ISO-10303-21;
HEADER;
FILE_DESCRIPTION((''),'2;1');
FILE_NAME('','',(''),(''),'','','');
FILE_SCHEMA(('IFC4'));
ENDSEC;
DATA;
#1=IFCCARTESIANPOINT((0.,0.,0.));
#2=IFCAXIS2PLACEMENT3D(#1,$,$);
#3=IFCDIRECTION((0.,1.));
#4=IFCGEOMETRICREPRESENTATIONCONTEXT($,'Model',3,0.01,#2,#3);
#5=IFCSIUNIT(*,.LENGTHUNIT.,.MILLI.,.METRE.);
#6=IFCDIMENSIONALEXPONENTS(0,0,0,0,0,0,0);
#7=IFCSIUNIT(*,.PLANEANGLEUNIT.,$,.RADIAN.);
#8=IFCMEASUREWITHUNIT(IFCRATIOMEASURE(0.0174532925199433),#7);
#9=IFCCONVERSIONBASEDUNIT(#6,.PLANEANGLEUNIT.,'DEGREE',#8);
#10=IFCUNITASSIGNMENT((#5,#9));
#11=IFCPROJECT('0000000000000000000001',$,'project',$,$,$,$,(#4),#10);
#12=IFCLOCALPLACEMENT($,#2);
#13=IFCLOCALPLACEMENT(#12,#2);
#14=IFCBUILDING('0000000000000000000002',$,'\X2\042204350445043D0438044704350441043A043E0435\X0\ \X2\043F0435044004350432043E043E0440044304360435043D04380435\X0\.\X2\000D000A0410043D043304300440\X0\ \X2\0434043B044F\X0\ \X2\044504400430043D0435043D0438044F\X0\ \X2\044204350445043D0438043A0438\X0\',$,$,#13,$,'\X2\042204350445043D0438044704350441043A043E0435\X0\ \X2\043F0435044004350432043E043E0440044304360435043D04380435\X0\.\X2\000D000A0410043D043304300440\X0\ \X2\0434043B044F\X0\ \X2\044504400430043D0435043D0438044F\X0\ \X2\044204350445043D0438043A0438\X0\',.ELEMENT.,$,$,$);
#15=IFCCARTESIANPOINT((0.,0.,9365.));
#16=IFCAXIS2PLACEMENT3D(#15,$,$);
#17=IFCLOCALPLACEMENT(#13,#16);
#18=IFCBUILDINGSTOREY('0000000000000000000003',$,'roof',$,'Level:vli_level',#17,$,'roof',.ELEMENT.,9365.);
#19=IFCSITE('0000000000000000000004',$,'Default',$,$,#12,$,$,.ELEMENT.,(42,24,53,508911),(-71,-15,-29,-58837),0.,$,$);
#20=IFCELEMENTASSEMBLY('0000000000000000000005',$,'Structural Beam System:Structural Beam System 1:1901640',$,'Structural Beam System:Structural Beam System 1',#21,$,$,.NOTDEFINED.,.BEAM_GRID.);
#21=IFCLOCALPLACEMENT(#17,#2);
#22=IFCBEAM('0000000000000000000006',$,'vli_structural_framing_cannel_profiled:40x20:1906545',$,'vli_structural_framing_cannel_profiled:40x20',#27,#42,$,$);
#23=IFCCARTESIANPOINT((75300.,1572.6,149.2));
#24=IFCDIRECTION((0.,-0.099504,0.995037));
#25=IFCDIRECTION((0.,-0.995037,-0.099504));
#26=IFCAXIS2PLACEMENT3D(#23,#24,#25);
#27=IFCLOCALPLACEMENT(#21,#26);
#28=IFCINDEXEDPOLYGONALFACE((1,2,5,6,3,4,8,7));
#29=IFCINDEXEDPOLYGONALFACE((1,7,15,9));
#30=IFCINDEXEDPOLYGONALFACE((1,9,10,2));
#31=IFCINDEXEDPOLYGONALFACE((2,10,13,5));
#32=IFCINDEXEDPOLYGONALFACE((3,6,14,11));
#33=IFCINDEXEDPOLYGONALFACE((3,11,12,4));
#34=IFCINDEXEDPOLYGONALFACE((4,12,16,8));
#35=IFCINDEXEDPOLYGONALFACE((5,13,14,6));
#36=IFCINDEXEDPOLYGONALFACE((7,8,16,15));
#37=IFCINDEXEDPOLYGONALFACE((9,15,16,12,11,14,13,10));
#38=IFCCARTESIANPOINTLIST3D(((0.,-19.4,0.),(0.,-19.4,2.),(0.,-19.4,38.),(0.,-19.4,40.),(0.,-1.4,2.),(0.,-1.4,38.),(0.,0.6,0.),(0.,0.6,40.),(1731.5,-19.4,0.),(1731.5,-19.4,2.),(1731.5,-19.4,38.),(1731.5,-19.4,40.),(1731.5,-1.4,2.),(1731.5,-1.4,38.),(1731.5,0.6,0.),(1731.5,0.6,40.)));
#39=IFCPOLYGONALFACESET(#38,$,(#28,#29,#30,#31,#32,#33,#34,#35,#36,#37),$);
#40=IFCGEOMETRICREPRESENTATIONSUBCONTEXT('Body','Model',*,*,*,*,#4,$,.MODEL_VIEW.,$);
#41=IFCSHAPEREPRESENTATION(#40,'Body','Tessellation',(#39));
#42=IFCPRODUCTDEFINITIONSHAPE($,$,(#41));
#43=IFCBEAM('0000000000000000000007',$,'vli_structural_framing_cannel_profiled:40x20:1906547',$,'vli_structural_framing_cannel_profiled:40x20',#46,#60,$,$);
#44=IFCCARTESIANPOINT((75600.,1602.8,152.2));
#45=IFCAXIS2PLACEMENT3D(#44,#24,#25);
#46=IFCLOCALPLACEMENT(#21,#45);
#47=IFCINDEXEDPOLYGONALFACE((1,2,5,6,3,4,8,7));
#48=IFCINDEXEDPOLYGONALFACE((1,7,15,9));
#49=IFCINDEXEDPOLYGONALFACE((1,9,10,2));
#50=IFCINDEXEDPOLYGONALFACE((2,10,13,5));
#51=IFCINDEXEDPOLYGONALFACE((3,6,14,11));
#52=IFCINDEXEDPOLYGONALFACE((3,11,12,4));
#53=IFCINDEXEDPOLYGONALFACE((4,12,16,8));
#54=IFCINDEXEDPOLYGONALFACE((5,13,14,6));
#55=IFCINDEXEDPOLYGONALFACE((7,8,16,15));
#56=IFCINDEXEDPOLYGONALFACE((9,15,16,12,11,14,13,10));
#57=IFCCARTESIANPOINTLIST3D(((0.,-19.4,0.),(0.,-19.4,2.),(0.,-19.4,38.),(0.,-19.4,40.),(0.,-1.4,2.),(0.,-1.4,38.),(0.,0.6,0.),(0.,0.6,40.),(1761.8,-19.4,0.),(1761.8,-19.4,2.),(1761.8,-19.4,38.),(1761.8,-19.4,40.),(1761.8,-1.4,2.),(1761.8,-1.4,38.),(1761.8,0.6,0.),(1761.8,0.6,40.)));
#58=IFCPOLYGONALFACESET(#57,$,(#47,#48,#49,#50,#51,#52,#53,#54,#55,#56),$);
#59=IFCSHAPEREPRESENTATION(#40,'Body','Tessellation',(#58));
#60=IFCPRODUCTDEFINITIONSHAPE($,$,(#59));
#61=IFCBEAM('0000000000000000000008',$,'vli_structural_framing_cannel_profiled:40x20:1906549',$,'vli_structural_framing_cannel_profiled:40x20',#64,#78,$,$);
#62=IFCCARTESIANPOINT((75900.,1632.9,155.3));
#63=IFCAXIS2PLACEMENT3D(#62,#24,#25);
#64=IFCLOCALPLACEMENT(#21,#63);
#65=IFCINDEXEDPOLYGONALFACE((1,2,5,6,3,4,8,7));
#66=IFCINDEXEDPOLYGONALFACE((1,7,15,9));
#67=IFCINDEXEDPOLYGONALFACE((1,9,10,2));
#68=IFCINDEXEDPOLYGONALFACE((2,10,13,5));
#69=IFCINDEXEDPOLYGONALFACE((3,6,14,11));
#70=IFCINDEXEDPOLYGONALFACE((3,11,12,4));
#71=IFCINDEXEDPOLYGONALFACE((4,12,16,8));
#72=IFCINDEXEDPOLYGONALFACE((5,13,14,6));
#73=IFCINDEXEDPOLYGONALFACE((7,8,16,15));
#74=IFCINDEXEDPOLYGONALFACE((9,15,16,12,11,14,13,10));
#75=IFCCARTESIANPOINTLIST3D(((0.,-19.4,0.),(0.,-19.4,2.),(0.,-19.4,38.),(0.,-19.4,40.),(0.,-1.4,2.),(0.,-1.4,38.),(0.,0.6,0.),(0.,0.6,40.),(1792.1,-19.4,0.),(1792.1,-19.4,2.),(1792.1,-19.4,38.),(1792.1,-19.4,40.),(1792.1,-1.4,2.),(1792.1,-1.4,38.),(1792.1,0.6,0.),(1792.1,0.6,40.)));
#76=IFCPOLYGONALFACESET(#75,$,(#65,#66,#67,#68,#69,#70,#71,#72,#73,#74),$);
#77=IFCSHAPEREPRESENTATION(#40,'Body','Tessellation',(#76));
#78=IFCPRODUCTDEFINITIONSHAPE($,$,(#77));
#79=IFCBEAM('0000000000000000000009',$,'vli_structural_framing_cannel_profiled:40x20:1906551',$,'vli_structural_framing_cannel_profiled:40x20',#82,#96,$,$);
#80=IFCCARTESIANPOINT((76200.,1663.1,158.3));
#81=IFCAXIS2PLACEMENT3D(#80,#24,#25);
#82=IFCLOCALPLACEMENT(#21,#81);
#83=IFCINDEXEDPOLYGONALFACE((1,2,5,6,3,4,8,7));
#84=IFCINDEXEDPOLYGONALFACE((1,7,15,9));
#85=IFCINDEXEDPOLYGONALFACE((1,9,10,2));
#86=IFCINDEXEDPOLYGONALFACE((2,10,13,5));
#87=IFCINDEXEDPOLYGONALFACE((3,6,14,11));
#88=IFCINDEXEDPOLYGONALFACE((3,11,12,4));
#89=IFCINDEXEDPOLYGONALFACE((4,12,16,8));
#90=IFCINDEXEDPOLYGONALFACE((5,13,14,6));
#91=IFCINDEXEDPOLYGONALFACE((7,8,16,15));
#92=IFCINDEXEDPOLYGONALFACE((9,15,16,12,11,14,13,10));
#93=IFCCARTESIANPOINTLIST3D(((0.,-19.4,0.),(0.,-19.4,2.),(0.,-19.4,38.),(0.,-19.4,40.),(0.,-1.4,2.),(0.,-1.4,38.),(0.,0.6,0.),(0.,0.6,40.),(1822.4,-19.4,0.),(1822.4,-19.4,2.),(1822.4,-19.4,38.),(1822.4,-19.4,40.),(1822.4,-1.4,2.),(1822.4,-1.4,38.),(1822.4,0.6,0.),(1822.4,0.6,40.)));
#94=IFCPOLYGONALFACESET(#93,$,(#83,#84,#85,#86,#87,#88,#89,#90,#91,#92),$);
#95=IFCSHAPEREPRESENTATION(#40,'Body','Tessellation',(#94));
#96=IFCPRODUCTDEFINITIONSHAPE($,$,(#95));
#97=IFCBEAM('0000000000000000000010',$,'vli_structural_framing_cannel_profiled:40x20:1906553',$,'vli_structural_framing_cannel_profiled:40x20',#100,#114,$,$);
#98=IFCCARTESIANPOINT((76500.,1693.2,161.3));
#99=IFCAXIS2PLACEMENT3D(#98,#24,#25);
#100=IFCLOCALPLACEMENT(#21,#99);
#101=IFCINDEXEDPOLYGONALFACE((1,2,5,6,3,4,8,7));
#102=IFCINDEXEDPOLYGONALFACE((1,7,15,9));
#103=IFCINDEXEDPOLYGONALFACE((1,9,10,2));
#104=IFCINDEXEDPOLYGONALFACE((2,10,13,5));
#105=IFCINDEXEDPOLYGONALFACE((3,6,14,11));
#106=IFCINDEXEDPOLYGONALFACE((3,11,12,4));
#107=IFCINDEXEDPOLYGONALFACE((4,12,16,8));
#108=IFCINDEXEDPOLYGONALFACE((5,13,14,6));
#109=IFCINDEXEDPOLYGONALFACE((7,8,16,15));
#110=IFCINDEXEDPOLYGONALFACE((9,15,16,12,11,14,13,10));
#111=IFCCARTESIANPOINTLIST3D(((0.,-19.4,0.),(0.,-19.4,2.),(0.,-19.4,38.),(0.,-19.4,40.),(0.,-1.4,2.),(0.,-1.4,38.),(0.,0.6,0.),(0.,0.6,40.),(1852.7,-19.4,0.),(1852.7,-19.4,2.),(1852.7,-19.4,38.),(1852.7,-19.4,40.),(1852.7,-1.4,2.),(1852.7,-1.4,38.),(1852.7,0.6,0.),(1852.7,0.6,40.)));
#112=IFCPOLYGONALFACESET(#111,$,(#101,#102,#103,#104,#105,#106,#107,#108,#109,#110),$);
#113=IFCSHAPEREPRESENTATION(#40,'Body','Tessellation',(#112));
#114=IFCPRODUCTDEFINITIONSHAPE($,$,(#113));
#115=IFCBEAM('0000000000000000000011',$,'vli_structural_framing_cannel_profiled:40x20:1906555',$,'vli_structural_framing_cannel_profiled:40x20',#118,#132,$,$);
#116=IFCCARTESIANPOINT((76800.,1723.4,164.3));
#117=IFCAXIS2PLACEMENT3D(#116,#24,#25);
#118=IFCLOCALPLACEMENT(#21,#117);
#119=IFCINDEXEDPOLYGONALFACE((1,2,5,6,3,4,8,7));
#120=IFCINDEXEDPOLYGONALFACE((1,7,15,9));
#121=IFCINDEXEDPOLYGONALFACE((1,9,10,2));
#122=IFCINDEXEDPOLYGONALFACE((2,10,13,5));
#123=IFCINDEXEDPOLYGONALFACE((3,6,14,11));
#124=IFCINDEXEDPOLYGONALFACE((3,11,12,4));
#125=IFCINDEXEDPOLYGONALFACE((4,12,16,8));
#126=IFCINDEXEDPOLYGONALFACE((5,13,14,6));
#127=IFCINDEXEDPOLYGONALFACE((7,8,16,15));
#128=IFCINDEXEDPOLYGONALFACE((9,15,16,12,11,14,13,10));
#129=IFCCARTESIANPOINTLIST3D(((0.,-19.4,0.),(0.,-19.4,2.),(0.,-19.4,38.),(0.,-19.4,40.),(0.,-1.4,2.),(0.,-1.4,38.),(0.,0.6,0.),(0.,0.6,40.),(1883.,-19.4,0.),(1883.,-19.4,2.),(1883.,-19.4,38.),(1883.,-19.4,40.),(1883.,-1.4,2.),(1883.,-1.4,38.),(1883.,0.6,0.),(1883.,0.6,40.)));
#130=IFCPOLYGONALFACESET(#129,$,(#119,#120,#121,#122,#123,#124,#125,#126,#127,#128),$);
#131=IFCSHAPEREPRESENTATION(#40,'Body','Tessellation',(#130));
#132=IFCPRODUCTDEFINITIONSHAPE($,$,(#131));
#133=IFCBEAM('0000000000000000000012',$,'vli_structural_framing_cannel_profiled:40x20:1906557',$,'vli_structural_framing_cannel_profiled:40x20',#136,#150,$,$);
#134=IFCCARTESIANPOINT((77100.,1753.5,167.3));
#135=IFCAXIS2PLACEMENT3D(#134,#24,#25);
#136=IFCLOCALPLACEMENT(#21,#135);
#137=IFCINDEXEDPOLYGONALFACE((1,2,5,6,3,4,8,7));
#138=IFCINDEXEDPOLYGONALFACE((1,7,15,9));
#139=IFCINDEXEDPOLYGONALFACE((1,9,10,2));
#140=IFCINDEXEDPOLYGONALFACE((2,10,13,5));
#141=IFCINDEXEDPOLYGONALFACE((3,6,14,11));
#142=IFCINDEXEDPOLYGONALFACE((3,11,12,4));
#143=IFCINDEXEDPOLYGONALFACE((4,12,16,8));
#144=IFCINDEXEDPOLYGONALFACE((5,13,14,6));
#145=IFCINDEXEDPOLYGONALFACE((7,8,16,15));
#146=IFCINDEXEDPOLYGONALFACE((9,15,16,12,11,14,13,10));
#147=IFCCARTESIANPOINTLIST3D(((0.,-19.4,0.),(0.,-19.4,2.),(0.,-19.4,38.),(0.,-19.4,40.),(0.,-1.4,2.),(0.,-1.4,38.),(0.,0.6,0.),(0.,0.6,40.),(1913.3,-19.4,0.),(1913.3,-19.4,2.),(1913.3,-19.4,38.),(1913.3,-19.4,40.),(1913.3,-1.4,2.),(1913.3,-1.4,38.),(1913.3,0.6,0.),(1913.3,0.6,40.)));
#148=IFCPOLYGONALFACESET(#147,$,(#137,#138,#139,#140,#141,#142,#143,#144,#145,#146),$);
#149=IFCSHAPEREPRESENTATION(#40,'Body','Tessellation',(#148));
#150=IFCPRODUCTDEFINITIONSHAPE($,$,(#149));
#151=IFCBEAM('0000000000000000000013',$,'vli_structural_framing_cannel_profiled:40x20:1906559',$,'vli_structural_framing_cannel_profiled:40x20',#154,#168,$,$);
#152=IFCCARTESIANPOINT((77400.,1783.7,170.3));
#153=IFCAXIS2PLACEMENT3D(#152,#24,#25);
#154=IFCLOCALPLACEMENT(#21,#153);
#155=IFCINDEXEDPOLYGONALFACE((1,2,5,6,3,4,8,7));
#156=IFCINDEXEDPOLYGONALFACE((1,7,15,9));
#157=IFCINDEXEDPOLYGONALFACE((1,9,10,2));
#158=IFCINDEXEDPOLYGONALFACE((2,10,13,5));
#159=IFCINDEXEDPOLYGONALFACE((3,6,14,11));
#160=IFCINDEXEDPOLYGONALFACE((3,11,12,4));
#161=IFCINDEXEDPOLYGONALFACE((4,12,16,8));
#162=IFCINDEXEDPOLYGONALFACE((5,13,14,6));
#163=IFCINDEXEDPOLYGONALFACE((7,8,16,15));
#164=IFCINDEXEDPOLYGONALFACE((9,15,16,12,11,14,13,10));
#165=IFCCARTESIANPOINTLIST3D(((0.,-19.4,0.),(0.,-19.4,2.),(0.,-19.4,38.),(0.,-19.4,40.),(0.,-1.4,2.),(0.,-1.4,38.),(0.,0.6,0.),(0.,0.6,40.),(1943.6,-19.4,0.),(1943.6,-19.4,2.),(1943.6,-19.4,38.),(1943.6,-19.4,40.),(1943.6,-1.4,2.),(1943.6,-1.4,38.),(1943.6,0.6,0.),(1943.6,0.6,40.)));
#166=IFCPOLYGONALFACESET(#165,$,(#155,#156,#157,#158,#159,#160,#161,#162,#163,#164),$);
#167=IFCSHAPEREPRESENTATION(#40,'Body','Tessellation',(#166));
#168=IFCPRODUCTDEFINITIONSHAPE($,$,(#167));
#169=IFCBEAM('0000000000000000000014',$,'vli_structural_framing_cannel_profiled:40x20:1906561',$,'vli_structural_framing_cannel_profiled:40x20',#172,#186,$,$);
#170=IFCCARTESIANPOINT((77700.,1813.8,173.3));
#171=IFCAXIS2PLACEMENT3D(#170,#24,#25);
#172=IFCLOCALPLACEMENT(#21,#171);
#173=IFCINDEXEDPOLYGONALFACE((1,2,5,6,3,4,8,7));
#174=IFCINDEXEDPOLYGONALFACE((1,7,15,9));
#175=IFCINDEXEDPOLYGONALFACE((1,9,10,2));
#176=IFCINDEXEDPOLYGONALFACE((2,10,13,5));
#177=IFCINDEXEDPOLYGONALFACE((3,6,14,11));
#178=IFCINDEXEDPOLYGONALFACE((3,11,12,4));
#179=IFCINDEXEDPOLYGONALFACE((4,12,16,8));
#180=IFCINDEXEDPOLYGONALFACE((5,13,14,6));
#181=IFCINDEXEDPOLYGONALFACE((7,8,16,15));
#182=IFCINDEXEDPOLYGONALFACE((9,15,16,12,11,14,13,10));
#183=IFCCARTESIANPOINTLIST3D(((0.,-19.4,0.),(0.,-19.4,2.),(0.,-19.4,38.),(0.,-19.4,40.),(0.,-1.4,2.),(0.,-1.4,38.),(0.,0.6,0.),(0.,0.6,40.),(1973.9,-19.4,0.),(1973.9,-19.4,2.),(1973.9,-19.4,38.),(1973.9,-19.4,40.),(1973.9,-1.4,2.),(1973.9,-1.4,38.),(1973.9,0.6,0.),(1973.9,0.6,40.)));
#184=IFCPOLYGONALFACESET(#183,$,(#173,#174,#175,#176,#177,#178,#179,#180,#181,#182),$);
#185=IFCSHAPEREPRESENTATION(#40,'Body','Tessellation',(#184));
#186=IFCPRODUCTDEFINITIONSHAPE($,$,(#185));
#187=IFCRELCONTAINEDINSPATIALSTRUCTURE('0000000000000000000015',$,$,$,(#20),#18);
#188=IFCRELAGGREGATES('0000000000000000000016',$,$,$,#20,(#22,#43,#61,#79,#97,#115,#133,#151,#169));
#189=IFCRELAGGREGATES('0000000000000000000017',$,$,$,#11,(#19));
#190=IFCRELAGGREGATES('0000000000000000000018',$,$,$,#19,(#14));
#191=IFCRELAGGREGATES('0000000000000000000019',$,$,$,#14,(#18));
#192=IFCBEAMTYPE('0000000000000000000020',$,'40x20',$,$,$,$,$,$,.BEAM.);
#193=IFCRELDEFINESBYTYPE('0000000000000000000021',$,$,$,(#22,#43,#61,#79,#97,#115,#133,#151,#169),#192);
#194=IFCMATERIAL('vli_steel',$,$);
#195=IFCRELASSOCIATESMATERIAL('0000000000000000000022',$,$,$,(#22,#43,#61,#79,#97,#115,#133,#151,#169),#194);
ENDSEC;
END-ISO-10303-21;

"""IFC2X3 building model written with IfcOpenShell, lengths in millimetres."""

from ifc_helpers import new_model, entity, si_unit, converted_unit, direction, frame, origin, place, context, subcontext, project, spatial, polyline, outline, extrude, material, type_object, element, aggregate, save


model = new_model("IFC2X3")

# Units and contexts
model_context = context("Model", 3, precision=0.01, world=origin(), true_north=direction((0.0, 1.0)))
body_context = subcontext(model_context, "Body", "Model", "MODEL_VIEW")
ifc_project = project(units=[si_unit("LENGTHUNIT", "METRE", prefix="MILLI"), converted_unit("PLANEANGLEUNIT", "DEGREE", entity("IfcRatioMeasure", 0.0174532925199433), si_unit("PLANEANGLEUNIT", "RADIAN"), dimensions=[0, 0, 0, 0, 0, 0, 0])], contexts=[model_context])

# Site, building, storey
site_placement = place(None, origin())
site = spatial("IfcSite", under=ifc_project, at=site_placement, Name="Default", CompositionType="ELEMENT", RefLatitude=(42, 24, 53, 508911), RefLongitude=(-71, -15, -29, -58837), RefElevation=0.0)
building_placement = place(site_placement, origin())
building = spatial("IfcBuilding", under=site, at=building_placement, Name="Техническое перевооружение.\r\nАнгар для хранения техники", LongName="Техническое перевооружение.\r\nАнгар для хранения техники", CompositionType="ELEMENT")
storey_placement = place(building_placement, frame((0.0, 0.0, 9365.0)))
storey = spatial("IfcBuildingStorey", under=building, at=storey_placement, Name="roof", ObjectType="Level:vli_level", LongName="roof", CompositionType="ELEMENT", Elevation=9365.0)

# Element assembly, beams
assembly_1_placement = place(storey_placement, origin())
assembly_1 = element("IfcElementAssembly", 1, at=assembly_1_placement, inside=storey, Name="Structural Beam System:Structural Beam System 1:1901640", ObjectType="Structural Beam System:Structural Beam System 1", AssemblyPlace="NOTDEFINED", PredefinedType="BEAM_GRID")
ifc_material = material(Name="vli_steel")
beam_type = type_object("IfcBeamType", Name="40x20", PredefinedType="BEAM")
beam_1_placement = place(assembly_1_placement, frame((75300.0, 1572.6, 149.2), z_axis=(0.0, -0.099504, 0.995037), x_axis=(0.0, -0.995037, -0.099504)))
beam_1 = element("IfcBeam", 2, at=beam_1_placement, type_object=beam_type, material=ifc_material, Name="vli_structural_framing_cannel_profiled:40x20:1906545", ObjectType="vli_structural_framing_cannel_profiled:40x20", context=body_context, shape_type="SweptSolid", body=[
    extrude(outline(polyline([(-20.0, -9.5), (-18.0, -9.5), (-18.0, 8.5), (18.0, 8.5), (18.0, -9.5), (20.0, -9.5), (20.0, 10.5), (-20.0, 10.5), (-20.0, -9.5)])), frame((0.0, -9.9, 20.0), z_axis=(1.0, 0.0, 0.0), x_axis=(0.0, 0.0, -1.0)), (0.0, 0.0, 1.0), 1731.5),
])
beam_2_placement = place(assembly_1_placement, frame((75600.0, 1602.8, 152.2), z_axis=(0.0, -0.099504, 0.995037), x_axis=(0.0, -0.995037, -0.099504)))
beam_2 = element("IfcBeam", 3, at=beam_2_placement, type_object=beam_type, material=ifc_material, Name="vli_structural_framing_cannel_profiled:40x20:1906547", ObjectType="vli_structural_framing_cannel_profiled:40x20", context=body_context, shape_type="SweptSolid", body=[
    extrude(outline(polyline([(-20.0, -9.5), (-18.0, -9.5), (-18.0, 8.5), (18.0, 8.5), (18.0, -9.5), (20.0, -9.5), (20.0, 10.5), (-20.0, 10.5), (-20.0, -9.5)])), frame((0.0, -9.9, 20.0), z_axis=(1.0, 0.0, 0.0), x_axis=(0.0, 0.0, -1.0)), (0.0, 0.0, 1.0), 1761.8),
])
beam_3_placement = place(assembly_1_placement, frame((75900.0, 1632.9, 155.3), z_axis=(0.0, -0.099504, 0.995037), x_axis=(0.0, -0.995037, -0.099504)))
beam_3 = element("IfcBeam", 4, at=beam_3_placement, type_object=beam_type, material=ifc_material, Name="vli_structural_framing_cannel_profiled:40x20:1906549", ObjectType="vli_structural_framing_cannel_profiled:40x20", context=body_context, shape_type="SweptSolid", body=[
    extrude(outline(polyline([(-20.0, -9.5), (-18.0, -9.5), (-18.0, 8.5), (18.0, 8.5), (18.0, -9.5), (20.0, -9.5), (20.0, 10.5), (-20.0, 10.5), (-20.0, -9.5)])), frame((0.0, -9.9, 20.0), z_axis=(1.0, 0.0, 0.0), x_axis=(0.0, 0.0, -1.0)), (0.0, 0.0, 1.0), 1792.1),
])
beam_4_placement = place(assembly_1_placement, frame((76200.0, 1663.1, 158.3), z_axis=(0.0, -0.099504, 0.995037), x_axis=(0.0, -0.995037, -0.099504)))
beam_4 = element("IfcBeam", 5, at=beam_4_placement, type_object=beam_type, material=ifc_material, Name="vli_structural_framing_cannel_profiled:40x20:1906551", ObjectType="vli_structural_framing_cannel_profiled:40x20", context=body_context, shape_type="SweptSolid", body=[
    extrude(outline(polyline([(-20.0, -9.5), (-18.0, -9.5), (-18.0, 8.5), (18.0, 8.5), (18.0, -9.5), (20.0, -9.5), (20.0, 10.5), (-20.0, 10.5), (-20.0, -9.5)])), frame((0.0, -9.9, 20.0), z_axis=(1.0, 0.0, 0.0), x_axis=(0.0, 0.0, -1.0)), (0.0, 0.0, 1.0), 1822.4),
])
beam_5_placement = place(assembly_1_placement, frame((76500.0, 1693.2, 161.3), z_axis=(0.0, -0.099504, 0.995037), x_axis=(0.0, -0.995037, -0.099504)))
beam_5 = element("IfcBeam", 6, at=beam_5_placement, type_object=beam_type, material=ifc_material, Name="vli_structural_framing_cannel_profiled:40x20:1906553", ObjectType="vli_structural_framing_cannel_profiled:40x20", context=body_context, shape_type="SweptSolid", body=[
    extrude(outline(polyline([(-20.0, -9.5), (-18.0, -9.5), (-18.0, 8.5), (18.0, 8.5), (18.0, -9.5), (20.0, -9.5), (20.0, 10.5), (-20.0, 10.5), (-20.0, -9.5)])), frame((0.0, -9.9, 20.0), z_axis=(1.0, 0.0, 0.0), x_axis=(0.0, 0.0, -1.0)), (0.0, 0.0, 1.0), 1852.7),
])
beam_6_placement = place(assembly_1_placement, frame((76800.0, 1723.4, 164.3), z_axis=(0.0, -0.099504, 0.995037), x_axis=(0.0, -0.995037, -0.099504)))
beam_6 = element("IfcBeam", 7, at=beam_6_placement, type_object=beam_type, material=ifc_material, Name="vli_structural_framing_cannel_profiled:40x20:1906555", ObjectType="vli_structural_framing_cannel_profiled:40x20", context=body_context, shape_type="SweptSolid", body=[
    extrude(outline(polyline([(-20.0, -9.5), (-18.0, -9.5), (-18.0, 8.5), (18.0, 8.5), (18.0, -9.5), (20.0, -9.5), (20.0, 10.5), (-20.0, 10.5), (-20.0, -9.5)])), frame((0.0, -9.9, 20.0), z_axis=(1.0, 0.0, 0.0), x_axis=(0.0, 0.0, -1.0)), (0.0, 0.0, 1.0), 1883.0),
])
beam_7_placement = place(assembly_1_placement, frame((77100.0, 1753.5, 167.3), z_axis=(0.0, -0.099504, 0.995037), x_axis=(0.0, -0.995037, -0.099504)))
beam_7 = element("IfcBeam", 8, at=beam_7_placement, type_object=beam_type, material=ifc_material, Name="vli_structural_framing_cannel_profiled:40x20:1906557", ObjectType="vli_structural_framing_cannel_profiled:40x20", context=body_context, shape_type="SweptSolid", body=[
    extrude(outline(polyline([(-20.0, -9.5), (-18.0, -9.5), (-18.0, 8.5), (18.0, 8.5), (18.0, -9.5), (20.0, -9.5), (20.0, 10.5), (-20.0, 10.5), (-20.0, -9.5)])), frame((0.0, -9.9, 20.0), z_axis=(1.0, 0.0, 0.0), x_axis=(0.0, 0.0, -1.0)), (0.0, 0.0, 1.0), 1913.3),
])
beam_8_placement = place(assembly_1_placement, frame((77400.0, 1783.7, 170.3), z_axis=(0.0, -0.099504, 0.995037), x_axis=(0.0, -0.995037, -0.099504)))
beam_8 = element("IfcBeam", 9, at=beam_8_placement, type_object=beam_type, material=ifc_material, Name="vli_structural_framing_cannel_profiled:40x20:1906559", ObjectType="vli_structural_framing_cannel_profiled:40x20", context=body_context, shape_type="SweptSolid", body=[
    extrude(outline(polyline([(-20.0, -9.5), (-18.0, -9.5), (-18.0, 8.5), (18.0, 8.5), (18.0, -9.5), (20.0, -9.5), (20.0, 10.5), (-20.0, 10.5), (-20.0, -9.5)])), frame((0.0, -9.9, 20.0), z_axis=(1.0, 0.0, 0.0), x_axis=(0.0, 0.0, -1.0)), (0.0, 0.0, 1.0), 1943.6),
])
beam_9_placement = place(assembly_1_placement, frame((77700.0, 1813.8, 173.3), z_axis=(0.0, -0.099504, 0.995037), x_axis=(0.0, -0.995037, -0.099504)))
beam_9 = element("IfcBeam", 10, at=beam_9_placement, type_object=beam_type, material=ifc_material, Name="vli_structural_framing_cannel_profiled:40x20:1906561", ObjectType="vli_structural_framing_cannel_profiled:40x20", context=body_context, shape_type="SweptSolid", body=[
    extrude(outline(polyline([(-20.0, -9.5), (-18.0, -9.5), (-18.0, 8.5), (18.0, 8.5), (18.0, -9.5), (20.0, -9.5), (20.0, 10.5), (-20.0, 10.5), (-20.0, -9.5)])), frame((0.0, -9.9, 20.0), z_axis=(1.0, 0.0, 0.0), x_axis=(0.0, 0.0, -1.0)), (0.0, 0.0, 1.0), 1973.9),
])
aggregate(assembly_1, [beam_1, beam_2, beam_3, beam_4, beam_5, beam_6, beam_7, beam_8, beam_9])

save(model, "model.ifc")
